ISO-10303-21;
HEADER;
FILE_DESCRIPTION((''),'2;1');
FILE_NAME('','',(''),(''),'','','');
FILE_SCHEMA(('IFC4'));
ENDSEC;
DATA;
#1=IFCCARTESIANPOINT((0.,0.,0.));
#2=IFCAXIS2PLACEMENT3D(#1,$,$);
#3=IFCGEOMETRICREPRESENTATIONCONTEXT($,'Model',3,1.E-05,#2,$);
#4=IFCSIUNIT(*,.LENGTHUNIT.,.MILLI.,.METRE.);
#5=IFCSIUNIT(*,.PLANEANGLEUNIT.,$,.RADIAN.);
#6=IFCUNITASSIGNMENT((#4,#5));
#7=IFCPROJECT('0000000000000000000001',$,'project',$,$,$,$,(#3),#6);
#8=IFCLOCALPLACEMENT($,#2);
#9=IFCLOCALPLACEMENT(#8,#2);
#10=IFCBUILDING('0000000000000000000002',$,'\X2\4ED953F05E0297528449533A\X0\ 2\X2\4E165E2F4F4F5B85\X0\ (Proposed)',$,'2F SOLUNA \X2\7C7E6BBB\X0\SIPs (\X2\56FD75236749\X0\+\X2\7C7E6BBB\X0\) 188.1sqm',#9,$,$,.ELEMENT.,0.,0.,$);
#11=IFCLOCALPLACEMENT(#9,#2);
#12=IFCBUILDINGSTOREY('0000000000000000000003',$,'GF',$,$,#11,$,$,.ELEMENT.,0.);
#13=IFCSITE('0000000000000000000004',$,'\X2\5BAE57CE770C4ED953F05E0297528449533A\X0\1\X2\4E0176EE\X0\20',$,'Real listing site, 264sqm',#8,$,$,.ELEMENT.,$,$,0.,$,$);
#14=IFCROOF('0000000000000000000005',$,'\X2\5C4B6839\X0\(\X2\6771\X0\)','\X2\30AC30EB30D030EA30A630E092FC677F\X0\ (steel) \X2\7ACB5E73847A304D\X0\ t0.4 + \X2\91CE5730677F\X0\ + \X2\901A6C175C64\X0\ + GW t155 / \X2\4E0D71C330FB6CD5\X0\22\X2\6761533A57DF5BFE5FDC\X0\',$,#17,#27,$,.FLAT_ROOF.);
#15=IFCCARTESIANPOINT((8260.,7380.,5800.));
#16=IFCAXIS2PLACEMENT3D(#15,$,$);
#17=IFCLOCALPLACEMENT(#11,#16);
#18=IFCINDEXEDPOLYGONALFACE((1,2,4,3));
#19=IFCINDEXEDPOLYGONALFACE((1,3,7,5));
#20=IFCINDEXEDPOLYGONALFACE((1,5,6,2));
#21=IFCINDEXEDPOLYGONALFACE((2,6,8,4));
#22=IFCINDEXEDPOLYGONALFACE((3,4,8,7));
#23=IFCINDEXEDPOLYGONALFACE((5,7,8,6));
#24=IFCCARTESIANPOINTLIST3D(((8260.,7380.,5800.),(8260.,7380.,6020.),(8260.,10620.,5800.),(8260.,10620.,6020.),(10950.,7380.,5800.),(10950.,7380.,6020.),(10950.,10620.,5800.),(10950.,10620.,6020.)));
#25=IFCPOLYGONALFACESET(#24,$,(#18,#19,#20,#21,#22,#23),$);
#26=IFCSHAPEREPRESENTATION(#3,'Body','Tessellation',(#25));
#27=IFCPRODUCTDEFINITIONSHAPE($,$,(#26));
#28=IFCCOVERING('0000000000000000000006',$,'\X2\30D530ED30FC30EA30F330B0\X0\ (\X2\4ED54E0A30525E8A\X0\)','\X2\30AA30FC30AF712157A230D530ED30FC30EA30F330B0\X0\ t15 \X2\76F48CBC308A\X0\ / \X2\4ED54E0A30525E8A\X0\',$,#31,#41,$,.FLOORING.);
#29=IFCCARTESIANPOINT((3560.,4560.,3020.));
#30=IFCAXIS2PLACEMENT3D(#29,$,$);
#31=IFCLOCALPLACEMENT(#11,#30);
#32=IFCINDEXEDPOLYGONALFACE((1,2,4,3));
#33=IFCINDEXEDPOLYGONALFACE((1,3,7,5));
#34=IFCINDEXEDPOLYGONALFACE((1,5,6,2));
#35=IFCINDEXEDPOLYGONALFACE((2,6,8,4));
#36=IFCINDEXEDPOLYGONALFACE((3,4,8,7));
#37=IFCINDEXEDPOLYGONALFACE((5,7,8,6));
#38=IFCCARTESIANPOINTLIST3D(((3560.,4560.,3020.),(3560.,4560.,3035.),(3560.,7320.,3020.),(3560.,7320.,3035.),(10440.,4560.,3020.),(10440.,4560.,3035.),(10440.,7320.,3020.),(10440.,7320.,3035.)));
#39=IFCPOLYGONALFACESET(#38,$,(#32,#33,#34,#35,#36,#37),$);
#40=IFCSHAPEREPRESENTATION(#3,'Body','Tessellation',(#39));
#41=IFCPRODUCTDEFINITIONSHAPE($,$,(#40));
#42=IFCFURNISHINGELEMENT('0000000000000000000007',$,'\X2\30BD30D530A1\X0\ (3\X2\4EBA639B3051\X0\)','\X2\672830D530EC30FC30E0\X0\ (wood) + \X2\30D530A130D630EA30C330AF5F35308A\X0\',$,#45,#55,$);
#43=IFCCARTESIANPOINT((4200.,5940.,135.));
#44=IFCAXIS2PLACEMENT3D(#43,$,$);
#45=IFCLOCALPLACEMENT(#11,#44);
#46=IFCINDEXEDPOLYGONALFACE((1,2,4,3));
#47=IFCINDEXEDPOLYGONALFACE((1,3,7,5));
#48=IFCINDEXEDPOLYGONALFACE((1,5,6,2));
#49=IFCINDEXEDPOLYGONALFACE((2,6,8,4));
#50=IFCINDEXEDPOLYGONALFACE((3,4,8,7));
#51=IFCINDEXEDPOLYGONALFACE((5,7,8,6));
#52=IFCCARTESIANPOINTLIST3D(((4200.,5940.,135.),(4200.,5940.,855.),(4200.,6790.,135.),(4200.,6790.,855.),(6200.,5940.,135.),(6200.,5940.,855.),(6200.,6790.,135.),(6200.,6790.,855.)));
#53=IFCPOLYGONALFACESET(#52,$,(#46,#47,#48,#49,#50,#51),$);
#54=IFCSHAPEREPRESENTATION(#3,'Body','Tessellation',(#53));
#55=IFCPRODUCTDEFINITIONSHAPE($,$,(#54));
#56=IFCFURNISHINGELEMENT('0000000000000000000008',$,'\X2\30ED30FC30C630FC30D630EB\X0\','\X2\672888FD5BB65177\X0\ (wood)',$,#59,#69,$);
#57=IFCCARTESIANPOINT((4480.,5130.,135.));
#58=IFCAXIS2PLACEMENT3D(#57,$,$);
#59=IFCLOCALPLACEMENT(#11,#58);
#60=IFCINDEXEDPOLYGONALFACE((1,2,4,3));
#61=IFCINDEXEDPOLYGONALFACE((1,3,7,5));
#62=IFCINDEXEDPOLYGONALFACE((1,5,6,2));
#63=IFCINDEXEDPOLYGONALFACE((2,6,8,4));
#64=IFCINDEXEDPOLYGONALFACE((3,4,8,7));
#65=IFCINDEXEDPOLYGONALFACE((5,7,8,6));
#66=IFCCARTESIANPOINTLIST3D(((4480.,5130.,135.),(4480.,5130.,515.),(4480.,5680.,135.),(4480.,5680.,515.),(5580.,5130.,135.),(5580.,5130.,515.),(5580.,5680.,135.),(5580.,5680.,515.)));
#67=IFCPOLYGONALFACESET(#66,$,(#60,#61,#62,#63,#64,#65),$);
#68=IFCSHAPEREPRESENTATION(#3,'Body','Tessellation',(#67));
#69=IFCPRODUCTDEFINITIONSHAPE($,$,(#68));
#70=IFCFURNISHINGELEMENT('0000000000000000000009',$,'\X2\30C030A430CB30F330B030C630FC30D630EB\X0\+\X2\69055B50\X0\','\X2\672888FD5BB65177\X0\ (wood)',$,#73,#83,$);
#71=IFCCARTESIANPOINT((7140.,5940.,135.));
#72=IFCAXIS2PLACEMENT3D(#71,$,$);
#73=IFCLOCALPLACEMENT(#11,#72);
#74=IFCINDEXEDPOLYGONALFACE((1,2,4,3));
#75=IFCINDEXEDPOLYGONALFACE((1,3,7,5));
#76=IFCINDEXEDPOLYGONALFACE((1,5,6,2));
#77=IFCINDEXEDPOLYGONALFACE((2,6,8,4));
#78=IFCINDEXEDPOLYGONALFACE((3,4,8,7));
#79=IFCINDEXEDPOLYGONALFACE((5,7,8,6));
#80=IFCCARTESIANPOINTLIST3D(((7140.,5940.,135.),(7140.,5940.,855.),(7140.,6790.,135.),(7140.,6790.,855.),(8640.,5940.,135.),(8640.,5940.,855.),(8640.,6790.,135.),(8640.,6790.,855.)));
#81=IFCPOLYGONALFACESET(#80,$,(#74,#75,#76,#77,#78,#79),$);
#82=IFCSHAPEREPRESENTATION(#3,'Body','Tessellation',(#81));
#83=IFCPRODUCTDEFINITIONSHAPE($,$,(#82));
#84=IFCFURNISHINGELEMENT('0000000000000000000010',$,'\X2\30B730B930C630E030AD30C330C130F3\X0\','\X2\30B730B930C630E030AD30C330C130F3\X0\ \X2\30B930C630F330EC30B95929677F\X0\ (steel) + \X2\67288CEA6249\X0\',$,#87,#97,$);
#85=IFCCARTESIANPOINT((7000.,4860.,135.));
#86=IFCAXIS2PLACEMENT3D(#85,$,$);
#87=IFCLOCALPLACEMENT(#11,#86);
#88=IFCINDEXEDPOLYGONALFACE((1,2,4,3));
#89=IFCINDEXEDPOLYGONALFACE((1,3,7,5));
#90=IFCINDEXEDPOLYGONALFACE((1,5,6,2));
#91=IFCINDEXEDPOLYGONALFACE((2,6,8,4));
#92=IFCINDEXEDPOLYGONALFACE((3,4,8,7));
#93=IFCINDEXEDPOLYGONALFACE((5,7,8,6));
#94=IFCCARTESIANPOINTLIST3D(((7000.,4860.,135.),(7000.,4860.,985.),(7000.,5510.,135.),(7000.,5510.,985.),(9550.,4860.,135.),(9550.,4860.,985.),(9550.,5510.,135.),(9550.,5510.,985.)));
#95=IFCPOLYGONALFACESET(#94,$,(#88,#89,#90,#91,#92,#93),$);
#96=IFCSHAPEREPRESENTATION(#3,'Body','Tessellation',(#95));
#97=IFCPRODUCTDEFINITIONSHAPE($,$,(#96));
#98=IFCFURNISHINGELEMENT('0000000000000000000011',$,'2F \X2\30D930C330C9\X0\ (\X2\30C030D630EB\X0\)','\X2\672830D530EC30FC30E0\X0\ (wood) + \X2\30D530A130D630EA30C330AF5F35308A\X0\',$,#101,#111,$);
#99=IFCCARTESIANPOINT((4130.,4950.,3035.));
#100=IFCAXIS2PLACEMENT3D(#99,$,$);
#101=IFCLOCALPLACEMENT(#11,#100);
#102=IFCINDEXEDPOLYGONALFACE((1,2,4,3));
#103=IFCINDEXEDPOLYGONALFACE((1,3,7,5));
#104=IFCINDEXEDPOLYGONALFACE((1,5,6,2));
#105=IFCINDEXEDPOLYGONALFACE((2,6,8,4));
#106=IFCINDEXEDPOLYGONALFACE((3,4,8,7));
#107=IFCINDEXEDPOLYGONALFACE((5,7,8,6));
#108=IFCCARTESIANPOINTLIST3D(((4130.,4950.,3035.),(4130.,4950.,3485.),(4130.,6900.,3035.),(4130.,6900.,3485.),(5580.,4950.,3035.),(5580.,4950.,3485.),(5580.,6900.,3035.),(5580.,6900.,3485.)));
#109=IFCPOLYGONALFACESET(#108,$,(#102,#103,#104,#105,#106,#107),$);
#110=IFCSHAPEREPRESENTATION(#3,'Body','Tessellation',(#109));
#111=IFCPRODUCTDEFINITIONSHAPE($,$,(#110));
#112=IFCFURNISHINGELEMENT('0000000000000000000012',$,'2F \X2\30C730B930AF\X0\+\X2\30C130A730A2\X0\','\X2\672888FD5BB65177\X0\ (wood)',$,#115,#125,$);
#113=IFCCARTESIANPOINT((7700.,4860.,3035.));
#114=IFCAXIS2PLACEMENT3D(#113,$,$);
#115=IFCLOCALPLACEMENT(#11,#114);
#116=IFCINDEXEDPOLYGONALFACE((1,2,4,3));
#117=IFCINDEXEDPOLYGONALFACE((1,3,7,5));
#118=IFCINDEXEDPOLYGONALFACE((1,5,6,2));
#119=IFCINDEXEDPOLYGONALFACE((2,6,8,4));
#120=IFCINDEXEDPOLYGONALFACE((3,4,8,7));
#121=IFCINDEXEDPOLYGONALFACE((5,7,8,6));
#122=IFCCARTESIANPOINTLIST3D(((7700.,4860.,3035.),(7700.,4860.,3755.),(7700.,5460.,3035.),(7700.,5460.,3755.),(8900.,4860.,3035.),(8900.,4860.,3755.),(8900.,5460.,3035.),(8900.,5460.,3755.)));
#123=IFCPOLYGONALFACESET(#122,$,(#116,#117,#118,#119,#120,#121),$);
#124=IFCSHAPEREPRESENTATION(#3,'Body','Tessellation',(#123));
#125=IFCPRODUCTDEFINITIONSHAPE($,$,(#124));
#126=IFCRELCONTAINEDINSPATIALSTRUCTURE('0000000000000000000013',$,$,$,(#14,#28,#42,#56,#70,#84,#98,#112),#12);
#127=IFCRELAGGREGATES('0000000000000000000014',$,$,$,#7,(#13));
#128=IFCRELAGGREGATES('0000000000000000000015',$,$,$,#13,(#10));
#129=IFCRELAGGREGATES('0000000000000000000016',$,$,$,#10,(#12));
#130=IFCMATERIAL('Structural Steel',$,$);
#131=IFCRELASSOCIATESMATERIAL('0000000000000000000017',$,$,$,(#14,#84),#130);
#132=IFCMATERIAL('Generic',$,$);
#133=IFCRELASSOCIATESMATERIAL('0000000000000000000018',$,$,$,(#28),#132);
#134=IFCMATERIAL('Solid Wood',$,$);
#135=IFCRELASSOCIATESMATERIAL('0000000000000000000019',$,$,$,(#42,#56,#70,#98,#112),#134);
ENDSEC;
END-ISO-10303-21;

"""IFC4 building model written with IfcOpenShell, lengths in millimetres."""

from ifc_helpers import new_model, si_unit, frame, frame_2d, origin, place, context, project, spatial, rectangle, extrude, material, element, save


model = new_model("IFC4")

# Units and contexts
model_context = context("Model", 3, precision=1e-05, world=origin())
ifc_project = project(units=[si_unit("LENGTHUNIT", "METRE", prefix="MILLI"), si_unit("PLANEANGLEUNIT", "RADIAN")], contexts=[model_context])

# Site, building, storey
site_placement = place(None, origin())
site = spatial("IfcSite", under=ifc_project, at=site_placement, Name="宮城県仙台市青葉区1丁目20", ObjectType="Real listing site, 264sqm", CompositionType="ELEMENT", RefElevation=0.0)
building_placement = place(site_placement, origin())
building = spatial("IfcBuilding", under=site, at=building_placement, Name="仙台市青葉区 2世帯住宅 (Proposed)", ObjectType="2F SOLUNA 籾殻SIPs (国産杉+籾殻) 188.1sqm", CompositionType="ELEMENT", ElevationOfRefHeight=0.0, ElevationOfTerrain=0.0)
storey_placement = place(building_placement, origin())
storey = spatial("IfcBuildingStorey", under=building, at=storey_placement, Name="GF", CompositionType="ELEMENT", Elevation=0.0)

# Shared definitions
ifc_material_1 = material(Name="Solid Wood")

# Shared definitions
ifc_material_2 = material(Name="Generic")

# Roof
ifc_material_3 = material(Name="Structural Steel")
roof_placement = place(storey_placement, frame((8260.0, 7380.0, 5800.0)))
element("IfcRoof", 1, at=roof_placement, inside=storey, material=ifc_material_3, Name="屋根(東)", Description="ガルバリウム鋼板 (steel) 立平葺き t0.4 + 野地板 + 通気層 + GW t155 / 不燃・法22条区域対応", PredefinedType="FLAT_ROOF", context=model_context, shape_type="SweptSolid", body=[
    extrude(rectangle(XDim=2690.0, YDim=3240.0, at=frame_2d((1345.0, 1620.0))), frame((8260.0, 7380.0, 5800.0)), (0.0, 0.0, 1.0), 220.0),
])

# Covering
covering_placement = place(storey_placement, frame((3560.0, 4560.0, 3020.0)))
element("IfcCovering", 2, at=covering_placement, inside=storey, material=ifc_material_2, Name="フローリング (仕上げ床)", Description="オーク無垢フローリング t15 直貼り / 仕上げ床", PredefinedType="FLOORING", context=model_context, shape_type="SweptSolid", body=[
    extrude(rectangle(XDim=6880.0, YDim=2760.0, at=frame_2d((3440.0, 1380.0))), frame((3560.0, 4560.0, 3020.0)), (0.0, 0.0, 1.0), 15.0),
])

# Furnishing elements
furnishing_1_placement = place(storey_placement, frame((4200.0, 5940.0, 135.0)))
element("IfcFurnishingElement", 3, at=furnishing_1_placement, inside=storey, material=ifc_material_1, Name="ソファ (3人掛け)", Description="木フレーム (wood) + ファブリック張り", context=model_context, shape_type="SweptSolid", body=[
    extrude(rectangle(XDim=2000.0, YDim=850.0, at=frame_2d((1000.0, 425.0))), frame((4200.0, 5940.0, 135.0)), (0.0, 0.0, 1.0), 720.0),
])
furnishing_2_placement = place(storey_placement, frame((4480.0, 5130.0, 135.0)))
element("IfcFurnishingElement", 4, at=furnishing_2_placement, inside=storey, material=ifc_material_1, Name="ローテーブル", Description="木製家具 (wood)", context=model_context, shape_type="SweptSolid", body=[
    extrude(rectangle(XDim=1100.0, YDim=550.0, at=frame_2d((550.0, 275.0))), frame((4480.0, 5130.0, 135.0)), (0.0, 0.0, 1.0), 380.0),
])
furnishing_3_placement = place(storey_placement, frame((7140.0, 5940.0, 135.0)))
element("IfcFurnishingElement", 5, at=furnishing_3_placement, inside=storey, material=ifc_material_1, Name="ダイニングテーブル+椅子", Description="木製家具 (wood)", context=model_context, shape_type="SweptSolid", body=[
    extrude(rectangle(XDim=1500.0, YDim=850.0, at=frame_2d((750.0, 425.0))), frame((7140.0, 5940.0, 135.0)), (0.0, 0.0, 1.0), 720.0),
])
furnishing_4_placement = place(storey_placement, frame((7000.0, 4860.0, 135.0)))
element("IfcFurnishingElement", 6, at=furnishing_4_placement, inside=storey, material=ifc_material_3, Name="システムキッチン", Description="システムキッチン ステンレス天板 (steel) + 木質扉", context=model_context, shape_type="SweptSolid", body=[
    extrude(rectangle(XDim=2550.0, YDim=650.0, at=frame_2d((1275.0, 325.0))), frame((7000.0, 4860.0, 135.0)), (0.0, 0.0, 1.0), 850.0),
])
furnishing_5_placement = place(storey_placement, frame((4130.0, 4950.0, 3035.0)))
element("IfcFurnishingElement", 7, at=furnishing_5_placement, inside=storey, material=ifc_material_1, Name="2F ベッド (ダブル)", Description="木フレーム (wood) + ファブリック張り", context=model_context, shape_type="SweptSolid", body=[
    extrude(rectangle(XDim=1450.0, YDim=1950.0, at=frame_2d((725.0, 975.0))), frame((4130.0, 4950.0, 3035.0)), (0.0, 0.0, 1.0), 450.0),
])
furnishing_6_placement = place(storey_placement, frame((7700.0, 4860.0, 3035.0)))
element("IfcFurnishingElement", 8, at=furnishing_6_placement, inside=storey, material=ifc_material_1, Name="2F デスク+チェア", Description="木製家具 (wood)", context=model_context, shape_type="SweptSolid", body=[
    extrude(rectangle(XDim=1200.0, YDim=600.0, at=frame_2d((600.0, 300.0))), frame((7700.0, 4860.0, 3035.0)), (0.0, 0.0, 1.0), 720.0),
])

save(model, "model.ifc")
